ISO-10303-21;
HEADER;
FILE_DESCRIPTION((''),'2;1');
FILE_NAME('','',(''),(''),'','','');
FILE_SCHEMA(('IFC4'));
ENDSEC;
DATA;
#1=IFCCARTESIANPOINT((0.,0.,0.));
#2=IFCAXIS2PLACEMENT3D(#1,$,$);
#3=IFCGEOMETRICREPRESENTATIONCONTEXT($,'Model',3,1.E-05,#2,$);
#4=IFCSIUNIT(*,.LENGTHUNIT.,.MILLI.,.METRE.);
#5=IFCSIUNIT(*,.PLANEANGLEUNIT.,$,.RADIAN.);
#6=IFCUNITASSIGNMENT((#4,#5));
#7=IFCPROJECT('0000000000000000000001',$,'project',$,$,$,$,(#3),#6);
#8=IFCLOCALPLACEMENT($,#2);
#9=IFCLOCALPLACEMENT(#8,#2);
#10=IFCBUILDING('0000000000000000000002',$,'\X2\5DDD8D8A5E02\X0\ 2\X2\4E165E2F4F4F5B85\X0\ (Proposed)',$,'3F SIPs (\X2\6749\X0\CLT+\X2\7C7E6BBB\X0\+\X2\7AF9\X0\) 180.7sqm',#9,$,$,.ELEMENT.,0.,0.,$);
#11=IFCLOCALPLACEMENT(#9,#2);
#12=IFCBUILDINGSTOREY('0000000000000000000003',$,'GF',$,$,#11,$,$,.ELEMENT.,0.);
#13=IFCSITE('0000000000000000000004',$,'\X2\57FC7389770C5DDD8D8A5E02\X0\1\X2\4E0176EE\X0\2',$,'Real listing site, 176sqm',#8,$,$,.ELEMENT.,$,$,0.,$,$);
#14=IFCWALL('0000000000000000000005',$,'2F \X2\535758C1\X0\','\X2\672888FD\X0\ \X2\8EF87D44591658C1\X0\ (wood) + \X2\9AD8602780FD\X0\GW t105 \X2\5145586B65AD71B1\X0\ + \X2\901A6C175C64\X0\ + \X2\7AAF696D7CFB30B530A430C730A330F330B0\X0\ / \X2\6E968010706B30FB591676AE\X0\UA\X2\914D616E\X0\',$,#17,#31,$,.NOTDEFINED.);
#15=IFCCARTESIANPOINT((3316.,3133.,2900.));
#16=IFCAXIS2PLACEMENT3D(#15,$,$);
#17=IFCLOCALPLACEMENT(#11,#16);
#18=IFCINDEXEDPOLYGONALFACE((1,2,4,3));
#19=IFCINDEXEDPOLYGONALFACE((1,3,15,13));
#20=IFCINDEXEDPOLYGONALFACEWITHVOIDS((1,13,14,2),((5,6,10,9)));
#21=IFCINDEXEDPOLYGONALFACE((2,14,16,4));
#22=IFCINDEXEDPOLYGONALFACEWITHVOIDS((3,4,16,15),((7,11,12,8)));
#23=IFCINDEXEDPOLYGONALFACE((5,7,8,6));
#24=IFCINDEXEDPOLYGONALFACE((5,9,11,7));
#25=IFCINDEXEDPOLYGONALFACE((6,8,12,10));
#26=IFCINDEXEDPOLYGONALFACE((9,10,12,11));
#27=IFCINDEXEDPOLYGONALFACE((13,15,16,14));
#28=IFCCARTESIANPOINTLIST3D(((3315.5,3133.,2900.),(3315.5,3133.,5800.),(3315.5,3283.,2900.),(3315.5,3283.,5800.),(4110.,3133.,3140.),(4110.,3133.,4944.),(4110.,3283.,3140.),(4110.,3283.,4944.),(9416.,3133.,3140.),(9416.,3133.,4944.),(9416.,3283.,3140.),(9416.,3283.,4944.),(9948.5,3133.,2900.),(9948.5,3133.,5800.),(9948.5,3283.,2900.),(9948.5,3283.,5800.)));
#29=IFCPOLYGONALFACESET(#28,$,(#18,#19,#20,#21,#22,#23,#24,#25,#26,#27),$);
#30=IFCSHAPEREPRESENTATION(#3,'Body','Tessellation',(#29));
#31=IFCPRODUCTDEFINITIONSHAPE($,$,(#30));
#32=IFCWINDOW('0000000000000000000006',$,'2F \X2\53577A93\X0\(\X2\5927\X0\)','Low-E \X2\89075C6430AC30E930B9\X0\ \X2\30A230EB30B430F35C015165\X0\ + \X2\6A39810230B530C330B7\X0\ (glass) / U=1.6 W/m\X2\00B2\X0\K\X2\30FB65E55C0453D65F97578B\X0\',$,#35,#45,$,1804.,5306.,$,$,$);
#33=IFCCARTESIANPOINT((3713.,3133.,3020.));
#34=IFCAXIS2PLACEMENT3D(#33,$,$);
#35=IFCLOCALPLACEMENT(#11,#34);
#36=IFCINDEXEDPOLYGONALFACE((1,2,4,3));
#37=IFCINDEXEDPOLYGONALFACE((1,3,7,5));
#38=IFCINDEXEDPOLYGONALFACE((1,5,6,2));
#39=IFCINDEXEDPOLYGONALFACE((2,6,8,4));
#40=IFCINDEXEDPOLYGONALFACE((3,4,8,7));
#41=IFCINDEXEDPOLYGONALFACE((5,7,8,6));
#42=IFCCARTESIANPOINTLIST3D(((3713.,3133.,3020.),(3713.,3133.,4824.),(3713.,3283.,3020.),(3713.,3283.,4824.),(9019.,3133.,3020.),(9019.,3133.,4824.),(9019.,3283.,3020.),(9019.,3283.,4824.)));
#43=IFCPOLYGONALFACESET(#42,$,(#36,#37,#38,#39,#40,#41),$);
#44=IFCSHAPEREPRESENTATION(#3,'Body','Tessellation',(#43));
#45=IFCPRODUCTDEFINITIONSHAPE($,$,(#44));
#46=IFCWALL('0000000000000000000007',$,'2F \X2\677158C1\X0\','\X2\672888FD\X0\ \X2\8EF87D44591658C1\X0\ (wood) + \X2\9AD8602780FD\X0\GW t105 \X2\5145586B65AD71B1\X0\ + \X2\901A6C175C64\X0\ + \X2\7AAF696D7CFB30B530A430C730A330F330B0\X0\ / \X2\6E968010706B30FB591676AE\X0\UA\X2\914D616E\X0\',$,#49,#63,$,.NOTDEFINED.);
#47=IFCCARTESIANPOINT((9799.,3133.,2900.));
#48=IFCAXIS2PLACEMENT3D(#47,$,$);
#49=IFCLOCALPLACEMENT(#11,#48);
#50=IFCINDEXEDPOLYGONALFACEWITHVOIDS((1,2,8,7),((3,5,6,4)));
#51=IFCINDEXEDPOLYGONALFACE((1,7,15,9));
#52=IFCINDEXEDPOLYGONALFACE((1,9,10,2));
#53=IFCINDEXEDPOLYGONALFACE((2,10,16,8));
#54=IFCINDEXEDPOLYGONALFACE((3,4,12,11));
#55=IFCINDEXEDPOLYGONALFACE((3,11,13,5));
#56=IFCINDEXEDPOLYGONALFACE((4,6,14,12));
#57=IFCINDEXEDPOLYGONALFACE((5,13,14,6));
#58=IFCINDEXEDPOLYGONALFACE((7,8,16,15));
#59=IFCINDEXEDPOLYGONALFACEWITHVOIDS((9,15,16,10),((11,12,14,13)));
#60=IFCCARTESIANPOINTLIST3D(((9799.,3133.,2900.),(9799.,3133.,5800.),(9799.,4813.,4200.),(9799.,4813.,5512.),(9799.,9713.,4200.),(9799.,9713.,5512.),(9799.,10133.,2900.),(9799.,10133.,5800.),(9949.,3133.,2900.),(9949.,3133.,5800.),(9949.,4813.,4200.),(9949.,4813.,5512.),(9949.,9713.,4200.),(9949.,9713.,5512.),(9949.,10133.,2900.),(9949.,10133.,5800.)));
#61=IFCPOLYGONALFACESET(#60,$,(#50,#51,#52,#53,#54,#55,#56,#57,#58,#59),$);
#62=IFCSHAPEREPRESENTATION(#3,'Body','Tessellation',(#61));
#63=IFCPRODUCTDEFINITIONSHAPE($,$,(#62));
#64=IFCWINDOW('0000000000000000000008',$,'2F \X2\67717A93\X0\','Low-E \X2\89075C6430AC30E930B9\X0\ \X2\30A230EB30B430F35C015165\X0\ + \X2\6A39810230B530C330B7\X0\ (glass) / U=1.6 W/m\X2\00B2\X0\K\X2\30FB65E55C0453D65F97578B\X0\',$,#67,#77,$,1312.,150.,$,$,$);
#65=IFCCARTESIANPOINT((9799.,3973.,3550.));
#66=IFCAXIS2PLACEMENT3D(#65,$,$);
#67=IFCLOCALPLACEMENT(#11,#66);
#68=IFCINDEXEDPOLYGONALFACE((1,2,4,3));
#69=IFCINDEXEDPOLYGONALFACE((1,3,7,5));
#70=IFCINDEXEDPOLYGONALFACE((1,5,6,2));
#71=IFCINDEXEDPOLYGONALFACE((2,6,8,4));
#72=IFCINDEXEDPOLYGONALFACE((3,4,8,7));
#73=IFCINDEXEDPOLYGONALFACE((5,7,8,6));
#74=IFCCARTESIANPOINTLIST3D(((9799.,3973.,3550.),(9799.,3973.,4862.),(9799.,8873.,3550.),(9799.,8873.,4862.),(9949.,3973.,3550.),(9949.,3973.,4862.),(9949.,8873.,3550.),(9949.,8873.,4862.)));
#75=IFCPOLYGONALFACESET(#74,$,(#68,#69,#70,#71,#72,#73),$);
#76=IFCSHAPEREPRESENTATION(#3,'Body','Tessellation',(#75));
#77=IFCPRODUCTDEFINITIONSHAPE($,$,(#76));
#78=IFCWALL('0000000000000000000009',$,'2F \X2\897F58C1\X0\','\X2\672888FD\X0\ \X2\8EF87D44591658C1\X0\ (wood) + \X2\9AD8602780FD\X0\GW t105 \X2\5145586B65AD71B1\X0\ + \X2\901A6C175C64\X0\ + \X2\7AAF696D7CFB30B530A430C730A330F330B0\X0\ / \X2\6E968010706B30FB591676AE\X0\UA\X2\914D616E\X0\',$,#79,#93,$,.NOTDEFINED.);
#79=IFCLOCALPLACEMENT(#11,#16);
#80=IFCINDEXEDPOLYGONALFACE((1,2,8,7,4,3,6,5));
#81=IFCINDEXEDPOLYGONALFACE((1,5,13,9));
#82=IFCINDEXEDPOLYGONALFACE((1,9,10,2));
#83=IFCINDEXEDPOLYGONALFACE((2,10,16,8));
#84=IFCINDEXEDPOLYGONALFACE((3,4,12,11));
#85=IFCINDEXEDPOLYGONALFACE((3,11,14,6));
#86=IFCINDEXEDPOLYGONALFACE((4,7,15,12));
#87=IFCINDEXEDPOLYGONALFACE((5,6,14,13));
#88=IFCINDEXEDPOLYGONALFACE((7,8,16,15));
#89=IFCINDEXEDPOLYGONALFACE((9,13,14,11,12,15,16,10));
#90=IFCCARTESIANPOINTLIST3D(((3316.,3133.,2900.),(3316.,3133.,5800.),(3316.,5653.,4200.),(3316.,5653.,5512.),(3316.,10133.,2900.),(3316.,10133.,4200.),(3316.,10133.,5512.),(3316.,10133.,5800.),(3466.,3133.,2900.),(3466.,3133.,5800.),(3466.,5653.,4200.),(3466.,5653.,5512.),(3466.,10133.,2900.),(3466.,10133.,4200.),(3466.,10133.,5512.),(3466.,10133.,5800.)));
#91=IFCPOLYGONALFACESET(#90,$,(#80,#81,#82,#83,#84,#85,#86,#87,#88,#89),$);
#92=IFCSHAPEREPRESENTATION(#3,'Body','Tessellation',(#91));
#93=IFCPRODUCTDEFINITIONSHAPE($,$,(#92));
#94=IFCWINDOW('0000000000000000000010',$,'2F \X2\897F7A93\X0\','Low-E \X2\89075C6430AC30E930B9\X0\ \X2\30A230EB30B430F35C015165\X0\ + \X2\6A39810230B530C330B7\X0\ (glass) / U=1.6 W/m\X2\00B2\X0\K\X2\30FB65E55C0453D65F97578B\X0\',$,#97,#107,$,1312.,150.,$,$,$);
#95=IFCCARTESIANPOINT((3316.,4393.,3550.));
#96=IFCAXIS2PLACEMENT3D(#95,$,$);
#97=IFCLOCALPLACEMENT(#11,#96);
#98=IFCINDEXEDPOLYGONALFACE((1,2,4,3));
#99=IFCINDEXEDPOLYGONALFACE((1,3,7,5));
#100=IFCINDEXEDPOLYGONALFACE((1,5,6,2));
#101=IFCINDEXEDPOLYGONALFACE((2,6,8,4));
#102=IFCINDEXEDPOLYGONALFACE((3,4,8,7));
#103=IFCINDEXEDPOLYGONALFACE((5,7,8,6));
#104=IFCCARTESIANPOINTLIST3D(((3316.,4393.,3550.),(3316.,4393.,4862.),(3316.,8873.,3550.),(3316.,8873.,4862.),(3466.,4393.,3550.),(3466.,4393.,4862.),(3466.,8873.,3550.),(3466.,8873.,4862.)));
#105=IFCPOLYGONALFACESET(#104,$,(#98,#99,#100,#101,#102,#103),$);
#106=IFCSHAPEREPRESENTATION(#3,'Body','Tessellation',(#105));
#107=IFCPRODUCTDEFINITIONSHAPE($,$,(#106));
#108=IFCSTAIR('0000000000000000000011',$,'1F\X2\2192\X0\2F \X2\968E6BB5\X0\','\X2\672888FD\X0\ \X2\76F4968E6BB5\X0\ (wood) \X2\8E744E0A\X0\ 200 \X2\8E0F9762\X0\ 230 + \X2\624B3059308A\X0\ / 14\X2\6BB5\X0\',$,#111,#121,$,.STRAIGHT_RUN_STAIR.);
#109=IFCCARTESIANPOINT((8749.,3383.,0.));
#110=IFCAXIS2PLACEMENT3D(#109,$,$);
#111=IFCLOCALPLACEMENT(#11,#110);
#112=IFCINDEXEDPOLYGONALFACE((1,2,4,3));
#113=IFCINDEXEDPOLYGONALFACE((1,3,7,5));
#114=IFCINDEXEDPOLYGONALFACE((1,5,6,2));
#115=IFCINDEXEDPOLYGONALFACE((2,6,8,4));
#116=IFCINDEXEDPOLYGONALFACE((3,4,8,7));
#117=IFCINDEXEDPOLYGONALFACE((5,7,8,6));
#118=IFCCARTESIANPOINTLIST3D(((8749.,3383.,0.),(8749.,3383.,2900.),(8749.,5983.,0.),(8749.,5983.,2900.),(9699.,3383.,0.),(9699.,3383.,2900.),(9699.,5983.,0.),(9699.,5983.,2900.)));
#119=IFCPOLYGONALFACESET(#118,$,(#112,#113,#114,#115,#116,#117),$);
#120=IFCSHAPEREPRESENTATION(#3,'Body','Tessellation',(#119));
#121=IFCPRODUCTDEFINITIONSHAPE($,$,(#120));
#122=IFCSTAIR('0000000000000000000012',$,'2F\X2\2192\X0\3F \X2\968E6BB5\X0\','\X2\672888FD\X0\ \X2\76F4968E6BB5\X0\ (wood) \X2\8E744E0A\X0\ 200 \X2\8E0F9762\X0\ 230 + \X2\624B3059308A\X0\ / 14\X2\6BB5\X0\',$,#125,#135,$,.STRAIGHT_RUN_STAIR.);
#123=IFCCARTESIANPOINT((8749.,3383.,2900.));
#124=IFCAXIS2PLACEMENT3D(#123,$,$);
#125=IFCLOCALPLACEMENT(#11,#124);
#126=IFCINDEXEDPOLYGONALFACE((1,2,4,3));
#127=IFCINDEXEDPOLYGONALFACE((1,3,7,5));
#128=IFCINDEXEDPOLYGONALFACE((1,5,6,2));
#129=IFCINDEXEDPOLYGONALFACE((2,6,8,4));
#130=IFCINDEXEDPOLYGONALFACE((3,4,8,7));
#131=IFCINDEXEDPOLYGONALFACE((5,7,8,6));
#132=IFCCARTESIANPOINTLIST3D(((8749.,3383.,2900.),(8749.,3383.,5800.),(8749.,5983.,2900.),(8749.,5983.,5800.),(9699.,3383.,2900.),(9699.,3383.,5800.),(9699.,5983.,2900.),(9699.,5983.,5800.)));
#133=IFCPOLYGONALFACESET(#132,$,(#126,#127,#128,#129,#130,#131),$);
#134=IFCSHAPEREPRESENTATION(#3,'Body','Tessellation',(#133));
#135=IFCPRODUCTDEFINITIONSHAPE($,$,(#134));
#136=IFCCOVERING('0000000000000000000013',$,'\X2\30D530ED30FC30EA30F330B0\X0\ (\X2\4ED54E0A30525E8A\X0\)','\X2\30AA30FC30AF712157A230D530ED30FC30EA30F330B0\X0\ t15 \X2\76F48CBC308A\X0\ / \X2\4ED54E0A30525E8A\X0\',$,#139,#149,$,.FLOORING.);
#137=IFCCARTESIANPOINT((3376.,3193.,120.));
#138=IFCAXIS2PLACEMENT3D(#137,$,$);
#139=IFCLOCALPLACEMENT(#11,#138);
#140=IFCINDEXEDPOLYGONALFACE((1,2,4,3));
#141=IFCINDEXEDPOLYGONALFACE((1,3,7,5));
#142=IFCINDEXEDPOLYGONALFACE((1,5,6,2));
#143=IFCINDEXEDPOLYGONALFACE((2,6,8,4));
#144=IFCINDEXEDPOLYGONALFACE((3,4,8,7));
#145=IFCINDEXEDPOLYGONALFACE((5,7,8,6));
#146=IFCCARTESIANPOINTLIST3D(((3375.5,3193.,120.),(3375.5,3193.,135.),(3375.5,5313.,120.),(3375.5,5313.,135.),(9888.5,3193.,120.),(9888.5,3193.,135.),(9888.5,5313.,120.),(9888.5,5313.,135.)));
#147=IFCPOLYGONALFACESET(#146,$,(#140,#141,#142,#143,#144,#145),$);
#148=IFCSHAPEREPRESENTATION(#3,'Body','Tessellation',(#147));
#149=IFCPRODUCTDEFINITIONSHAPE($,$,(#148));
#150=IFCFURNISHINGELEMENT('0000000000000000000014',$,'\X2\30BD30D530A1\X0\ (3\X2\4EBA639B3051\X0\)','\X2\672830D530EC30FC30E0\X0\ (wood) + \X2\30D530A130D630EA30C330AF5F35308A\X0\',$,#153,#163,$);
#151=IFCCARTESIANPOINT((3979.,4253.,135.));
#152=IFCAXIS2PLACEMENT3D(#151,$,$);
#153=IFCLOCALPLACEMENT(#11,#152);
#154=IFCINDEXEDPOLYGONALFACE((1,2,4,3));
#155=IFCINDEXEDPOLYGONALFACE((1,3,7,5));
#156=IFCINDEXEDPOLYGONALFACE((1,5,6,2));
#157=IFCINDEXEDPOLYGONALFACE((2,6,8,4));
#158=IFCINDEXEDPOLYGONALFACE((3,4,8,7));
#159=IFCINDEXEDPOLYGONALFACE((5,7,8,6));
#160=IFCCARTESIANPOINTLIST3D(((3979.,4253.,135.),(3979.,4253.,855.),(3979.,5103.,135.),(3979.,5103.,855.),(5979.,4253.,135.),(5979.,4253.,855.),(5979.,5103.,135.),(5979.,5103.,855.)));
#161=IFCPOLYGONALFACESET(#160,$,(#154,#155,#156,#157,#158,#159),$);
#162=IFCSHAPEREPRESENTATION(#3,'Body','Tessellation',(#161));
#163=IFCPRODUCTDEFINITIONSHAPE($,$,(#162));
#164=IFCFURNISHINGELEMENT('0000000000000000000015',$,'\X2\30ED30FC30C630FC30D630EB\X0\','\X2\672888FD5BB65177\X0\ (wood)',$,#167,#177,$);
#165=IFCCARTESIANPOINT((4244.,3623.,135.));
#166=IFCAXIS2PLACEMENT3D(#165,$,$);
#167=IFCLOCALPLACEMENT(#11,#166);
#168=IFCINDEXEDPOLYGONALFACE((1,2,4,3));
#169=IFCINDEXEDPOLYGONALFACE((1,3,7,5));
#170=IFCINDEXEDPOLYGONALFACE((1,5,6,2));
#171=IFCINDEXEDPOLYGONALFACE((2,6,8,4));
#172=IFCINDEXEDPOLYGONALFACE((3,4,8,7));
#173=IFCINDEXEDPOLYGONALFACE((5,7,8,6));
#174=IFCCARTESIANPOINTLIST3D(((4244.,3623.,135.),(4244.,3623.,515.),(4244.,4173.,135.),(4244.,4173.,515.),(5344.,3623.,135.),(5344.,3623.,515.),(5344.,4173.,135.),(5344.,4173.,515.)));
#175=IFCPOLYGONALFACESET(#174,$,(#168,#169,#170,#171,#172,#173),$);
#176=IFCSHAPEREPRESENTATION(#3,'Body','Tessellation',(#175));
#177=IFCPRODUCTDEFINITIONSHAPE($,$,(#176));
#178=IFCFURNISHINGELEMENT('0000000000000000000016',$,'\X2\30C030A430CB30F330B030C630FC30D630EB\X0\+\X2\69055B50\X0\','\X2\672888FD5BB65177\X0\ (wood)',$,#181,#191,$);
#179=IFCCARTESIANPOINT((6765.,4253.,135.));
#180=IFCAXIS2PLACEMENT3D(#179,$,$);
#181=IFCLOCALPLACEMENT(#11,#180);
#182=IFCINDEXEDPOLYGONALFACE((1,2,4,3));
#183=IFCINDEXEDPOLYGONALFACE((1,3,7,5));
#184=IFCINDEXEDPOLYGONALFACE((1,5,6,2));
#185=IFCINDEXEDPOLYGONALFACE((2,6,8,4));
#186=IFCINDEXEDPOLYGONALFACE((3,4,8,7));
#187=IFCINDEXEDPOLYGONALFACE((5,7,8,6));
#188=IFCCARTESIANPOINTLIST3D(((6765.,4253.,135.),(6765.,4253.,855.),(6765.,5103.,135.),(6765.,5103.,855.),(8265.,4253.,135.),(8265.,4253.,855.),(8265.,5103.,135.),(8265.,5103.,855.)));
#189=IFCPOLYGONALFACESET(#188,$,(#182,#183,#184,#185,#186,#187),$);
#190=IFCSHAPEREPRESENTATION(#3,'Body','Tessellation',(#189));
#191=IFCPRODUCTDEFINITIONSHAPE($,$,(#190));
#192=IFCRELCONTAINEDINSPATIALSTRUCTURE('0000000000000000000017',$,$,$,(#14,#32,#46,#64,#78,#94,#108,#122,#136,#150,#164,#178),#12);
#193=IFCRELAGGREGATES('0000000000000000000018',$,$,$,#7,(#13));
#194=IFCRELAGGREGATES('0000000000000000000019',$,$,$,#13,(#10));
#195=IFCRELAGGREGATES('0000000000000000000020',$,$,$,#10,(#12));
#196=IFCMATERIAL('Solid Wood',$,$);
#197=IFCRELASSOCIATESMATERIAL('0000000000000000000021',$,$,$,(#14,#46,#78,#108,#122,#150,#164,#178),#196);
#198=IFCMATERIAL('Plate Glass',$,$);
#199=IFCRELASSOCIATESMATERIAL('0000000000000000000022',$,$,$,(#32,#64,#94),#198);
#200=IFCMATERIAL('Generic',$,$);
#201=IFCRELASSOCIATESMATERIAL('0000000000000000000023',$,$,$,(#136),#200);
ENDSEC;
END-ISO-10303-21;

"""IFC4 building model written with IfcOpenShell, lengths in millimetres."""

from ifc_helpers import new_model, si_unit, frame, frame_2d, origin, place, context, project, spatial, rectangle, extrude, material, element, fill, save


model = new_model("IFC4")

# Units and contexts
model_context = context("Model", 3, precision=1e-05, world=origin())
ifc_project = project(units=[si_unit("LENGTHUNIT", "METRE", prefix="MILLI"), si_unit("PLANEANGLEUNIT", "RADIAN")], contexts=[model_context])

# Site, building, storey
site_placement = place(None, origin())
site = spatial("IfcSite", under=ifc_project, at=site_placement, Name="埼玉県川越市1丁目2", ObjectType="Real listing site, 176sqm", CompositionType="ELEMENT", RefElevation=0.0)
building_placement = place(site_placement, origin())
building = spatial("IfcBuilding", under=site, at=building_placement, Name="川越市 2世帯住宅 (Proposed)", ObjectType="3F SIPs (杉CLT+籾殻+竹) 180.7sqm", CompositionType="ELEMENT", ElevationOfRefHeight=0.0, ElevationOfTerrain=0.0)
storey_placement = place(building_placement, origin())
storey = spatial("IfcBuildingStorey", under=building, at=storey_placement, Name="GF", CompositionType="ELEMENT", Elevation=0.0)

# Shared definitions
ifc_material_1 = material(Name="Solid Wood")
ifc_material_2 = material(Name="Generic")

# Shared definitions
ifc_material_3 = material(Name="Plate Glass")

# Walls, openings, windows
wall_1_placement = place(storey_placement, frame((3316.0, 3133.0, 2900.0)))
wall_1 = element("IfcWall", 1, at=wall_1_placement, inside=storey, material=ifc_material_1, Name="2F 南壁", Description="木製 軸組外壁 (wood) + 高性能GW t105 充填断熱 + 通気層 + 窯業系サイディング / 準耐火・外皮UA配慮", PredefinedType="NOTDEFINED", context=model_context, shape_type="SweptSolid", body=[
    extrude(rectangle(XDim=6633.0, YDim=150.0, at=frame_2d((3316.0, 75.0))), frame((3316.0, 3133.0, 2900.0)), (0.0, 0.0, 1.0), 2900.0),
])
opening_1_placement = place(storey_placement, frame((3713.0, 3133.0, 3020.0)))
opening_1 = element("IfcOpeningElement", 2, at=opening_1_placement, cuts=wall_1, PredefinedType="NOTDEFINED", context=model_context, shape_type="SweptSolid", body=[
    extrude(rectangle(XDim=5306.0, YDim=150.0, at=frame_2d((2653.0, 75.0))), frame((3713.0, 3133.0, 3020.0)), (0.0, 0.0, 1.0), 1804.0),
])
window_1_placement = place(storey_placement, frame((3713.0, 3133.0, 3020.0)))
window_1 = element("IfcWindow", 3, at=window_1_placement, inside=storey, material=ifc_material_3, Name="2F 南窓(大)", Description="Low-E 複層ガラス アルゴン封入 + 樹脂サッシ (glass) / U=1.6 W/m²K・日射取得型", OverallHeight=1804.0, OverallWidth=5306.0, context=model_context, shape_type="SweptSolid", body=[
    extrude(rectangle(XDim=5306.0, YDim=150.0, at=frame_2d((2653.0, 75.0))), frame((3713.0, 3133.0, 3020.0)), (0.0, 0.0, 1.0), 1804.0),
])
fill(opening_1, window_1)
wall_2_placement = place(storey_placement, frame((9799.0, 3133.0, 2900.0)))
wall_2 = element("IfcWall", 4, at=wall_2_placement, inside=storey, material=ifc_material_1, Name="2F 東壁", Description="木製 軸組外壁 (wood) + 高性能GW t105 充填断熱 + 通気層 + 窯業系サイディング / 準耐火・外皮UA配慮", PredefinedType="NOTDEFINED", context=model_context, shape_type="SweptSolid", body=[
    extrude(rectangle(XDim=150.0, YDim=7000.0, at=frame_2d((75.0, 3500.0))), frame((9799.0, 3133.0, 2900.0)), (0.0, 0.0, 1.0), 2900.0),
])
opening_2_placement = place(storey_placement, frame((9799.0, 3973.0, 3550.0)))
opening_2 = element("IfcOpeningElement", 5, at=opening_2_placement, cuts=wall_2, PredefinedType="NOTDEFINED", context=model_context, shape_type="SweptSolid", body=[
    extrude(rectangle(XDim=150.0, YDim=4900.0, at=frame_2d((75.0, 2450.0))), frame((9799.0, 3973.0, 3550.0)), (0.0, 0.0, 1.0), 1312.0),
])
window_2_placement = place(storey_placement, frame((9799.0, 3973.0, 3550.0)))
window_2 = element("IfcWindow", 6, at=window_2_placement, inside=storey, material=ifc_material_3, Name="2F 東窓", Description="Low-E 複層ガラス アルゴン封入 + 樹脂サッシ (glass) / U=1.6 W/m²K・日射取得型", OverallHeight=1312.0, OverallWidth=150.0, context=model_context, shape_type="SweptSolid", body=[
    extrude(rectangle(XDim=150.0, YDim=4900.0, at=frame_2d((75.0, 2450.0))), frame((9799.0, 3973.0, 3550.0)), (0.0, 0.0, 1.0), 1312.0),
])
fill(opening_2, window_2)
wall_3_placement = place(storey_placement, frame((3316.0, 3133.0, 2900.0)))
wall_3 = element("IfcWall", 7, at=wall_3_placement, inside=storey, material=ifc_material_1, Name="2F 西壁", Description="木製 軸組外壁 (wood) + 高性能GW t105 充填断熱 + 通気層 + 窯業系サイディング / 準耐火・外皮UA配慮", PredefinedType="NOTDEFINED", context=model_context, shape_type="SweptSolid", body=[
    extrude(rectangle(XDim=150.0, YDim=7000.0, at=frame_2d((75.0, 3500.0))), frame((3316.0, 3133.0, 2900.0)), (0.0, 0.0, 1.0), 2900.0),
])
opening_3_placement = place(storey_placement, frame((3316.0, 4393.0, 3550.0)))
opening_3 = element("IfcOpeningElement", 8, at=opening_3_placement, cuts=wall_3, PredefinedType="NOTDEFINED", context=model_context, shape_type="SweptSolid", body=[
    extrude(rectangle(XDim=150.0, YDim=4480.0, at=frame_2d((75.0, 2240.0))), frame((3316.0, 4393.0, 3550.0)), (0.0, 0.0, 1.0), 1312.0),
])
window_3_placement = place(storey_placement, frame((3316.0, 4393.0, 3550.0)))
window_3 = element("IfcWindow", 9, at=window_3_placement, inside=storey, material=ifc_material_3, Name="2F 西窓", Description="Low-E 複層ガラス アルゴン封入 + 樹脂サッシ (glass) / U=1.6 W/m²K・日射取得型", OverallHeight=1312.0, OverallWidth=150.0, context=model_context, shape_type="SweptSolid", body=[
    extrude(rectangle(XDim=150.0, YDim=4480.0, at=frame_2d((75.0, 2240.0))), frame((3316.0, 4393.0, 3550.0)), (0.0, 0.0, 1.0), 1312.0),
])
fill(opening_3, window_3)

# Stairs
stair_1_placement = place(storey_placement, frame((8749.0, 3383.0, 0.0)))
element("IfcStair", 10, at=stair_1_placement, inside=storey, material=ifc_material_1, Name="1F→2F 階段", Description="木製 直階段 (wood) 蹴上 200 踏面 230 + 手すり / 14段", PredefinedType="STRAIGHT_RUN_STAIR", context=model_context, shape_type="SweptSolid", body=[
    extrude(rectangle(XDim=950.0, YDim=2600.0, at=frame_2d((475.0, 1300.0))), frame((8749.0, 3383.0, 0.0)), (0.0, 0.0, 1.0), 2900.0),
])
stair_2_placement = place(storey_placement, frame((8749.0, 3383.0, 2900.0)))
element("IfcStair", 11, at=stair_2_placement, inside=storey, material=ifc_material_1, Name="2F→3F 階段", Description="木製 直階段 (wood) 蹴上 200 踏面 230 + 手すり / 14段", PredefinedType="STRAIGHT_RUN_STAIR", context=model_context, shape_type="SweptSolid", body=[
    extrude(rectangle(XDim=950.0, YDim=2600.0, at=frame_2d((475.0, 1300.0))), frame((8749.0, 3383.0, 2900.0)), (0.0, 0.0, 1.0), 2900.0),
])

# Covering
covering_placement = place(storey_placement, frame((3376.0, 3193.0, 120.0)))
element("IfcCovering", 12, at=covering_placement, inside=storey, material=ifc_material_2, Name="フローリング (仕上げ床)", Description="オーク無垢フローリング t15 直貼り / 仕上げ床", PredefinedType="FLOORING", context=model_context, shape_type="SweptSolid", body=[
    extrude(rectangle(XDim=6513.0, YDim=2120.0, at=frame_2d((3256.0, 1060.0))), frame((3376.0, 3193.0, 120.0)), (0.0, 0.0, 1.0), 15.0),
])

# Furnishing elements
furnishing_1_placement = place(storey_placement, frame((3979.0, 4253.0, 135.0)))
element("IfcFurnishingElement", 13, at=furnishing_1_placement, inside=storey, material=ifc_material_1, Name="ソファ (3人掛け)", Description="木フレーム (wood) + ファブリック張り", context=model_context, shape_type="SweptSolid", body=[
    extrude(rectangle(XDim=2000.0, YDim=850.0, at=frame_2d((1000.0, 425.0))), frame((3979.0, 4253.0, 135.0)), (0.0, 0.0, 1.0), 720.0),
])
furnishing_2_placement = place(storey_placement, frame((4244.0, 3623.0, 135.0)))
element("IfcFurnishingElement", 14, at=furnishing_2_placement, inside=storey, material=ifc_material_1, Name="ローテーブル", Description="木製家具 (wood)", context=model_context, shape_type="SweptSolid", body=[
    extrude(rectangle(XDim=1100.0, YDim=550.0, at=frame_2d((550.0, 275.0))), frame((4244.0, 3623.0, 135.0)), (0.0, 0.0, 1.0), 380.0),
])
furnishing_3_placement = place(storey_placement, frame((6765.0, 4253.0, 135.0)))
element("IfcFurnishingElement", 15, at=furnishing_3_placement, inside=storey, material=ifc_material_1, Name="ダイニングテーブル+椅子", Description="木製家具 (wood)", context=model_context, shape_type="SweptSolid", body=[
    extrude(rectangle(XDim=1500.0, YDim=850.0, at=frame_2d((750.0, 425.0))), frame((6765.0, 4253.0, 135.0)), (0.0, 0.0, 1.0), 720.0),
])

save(model, "model.ifc")
